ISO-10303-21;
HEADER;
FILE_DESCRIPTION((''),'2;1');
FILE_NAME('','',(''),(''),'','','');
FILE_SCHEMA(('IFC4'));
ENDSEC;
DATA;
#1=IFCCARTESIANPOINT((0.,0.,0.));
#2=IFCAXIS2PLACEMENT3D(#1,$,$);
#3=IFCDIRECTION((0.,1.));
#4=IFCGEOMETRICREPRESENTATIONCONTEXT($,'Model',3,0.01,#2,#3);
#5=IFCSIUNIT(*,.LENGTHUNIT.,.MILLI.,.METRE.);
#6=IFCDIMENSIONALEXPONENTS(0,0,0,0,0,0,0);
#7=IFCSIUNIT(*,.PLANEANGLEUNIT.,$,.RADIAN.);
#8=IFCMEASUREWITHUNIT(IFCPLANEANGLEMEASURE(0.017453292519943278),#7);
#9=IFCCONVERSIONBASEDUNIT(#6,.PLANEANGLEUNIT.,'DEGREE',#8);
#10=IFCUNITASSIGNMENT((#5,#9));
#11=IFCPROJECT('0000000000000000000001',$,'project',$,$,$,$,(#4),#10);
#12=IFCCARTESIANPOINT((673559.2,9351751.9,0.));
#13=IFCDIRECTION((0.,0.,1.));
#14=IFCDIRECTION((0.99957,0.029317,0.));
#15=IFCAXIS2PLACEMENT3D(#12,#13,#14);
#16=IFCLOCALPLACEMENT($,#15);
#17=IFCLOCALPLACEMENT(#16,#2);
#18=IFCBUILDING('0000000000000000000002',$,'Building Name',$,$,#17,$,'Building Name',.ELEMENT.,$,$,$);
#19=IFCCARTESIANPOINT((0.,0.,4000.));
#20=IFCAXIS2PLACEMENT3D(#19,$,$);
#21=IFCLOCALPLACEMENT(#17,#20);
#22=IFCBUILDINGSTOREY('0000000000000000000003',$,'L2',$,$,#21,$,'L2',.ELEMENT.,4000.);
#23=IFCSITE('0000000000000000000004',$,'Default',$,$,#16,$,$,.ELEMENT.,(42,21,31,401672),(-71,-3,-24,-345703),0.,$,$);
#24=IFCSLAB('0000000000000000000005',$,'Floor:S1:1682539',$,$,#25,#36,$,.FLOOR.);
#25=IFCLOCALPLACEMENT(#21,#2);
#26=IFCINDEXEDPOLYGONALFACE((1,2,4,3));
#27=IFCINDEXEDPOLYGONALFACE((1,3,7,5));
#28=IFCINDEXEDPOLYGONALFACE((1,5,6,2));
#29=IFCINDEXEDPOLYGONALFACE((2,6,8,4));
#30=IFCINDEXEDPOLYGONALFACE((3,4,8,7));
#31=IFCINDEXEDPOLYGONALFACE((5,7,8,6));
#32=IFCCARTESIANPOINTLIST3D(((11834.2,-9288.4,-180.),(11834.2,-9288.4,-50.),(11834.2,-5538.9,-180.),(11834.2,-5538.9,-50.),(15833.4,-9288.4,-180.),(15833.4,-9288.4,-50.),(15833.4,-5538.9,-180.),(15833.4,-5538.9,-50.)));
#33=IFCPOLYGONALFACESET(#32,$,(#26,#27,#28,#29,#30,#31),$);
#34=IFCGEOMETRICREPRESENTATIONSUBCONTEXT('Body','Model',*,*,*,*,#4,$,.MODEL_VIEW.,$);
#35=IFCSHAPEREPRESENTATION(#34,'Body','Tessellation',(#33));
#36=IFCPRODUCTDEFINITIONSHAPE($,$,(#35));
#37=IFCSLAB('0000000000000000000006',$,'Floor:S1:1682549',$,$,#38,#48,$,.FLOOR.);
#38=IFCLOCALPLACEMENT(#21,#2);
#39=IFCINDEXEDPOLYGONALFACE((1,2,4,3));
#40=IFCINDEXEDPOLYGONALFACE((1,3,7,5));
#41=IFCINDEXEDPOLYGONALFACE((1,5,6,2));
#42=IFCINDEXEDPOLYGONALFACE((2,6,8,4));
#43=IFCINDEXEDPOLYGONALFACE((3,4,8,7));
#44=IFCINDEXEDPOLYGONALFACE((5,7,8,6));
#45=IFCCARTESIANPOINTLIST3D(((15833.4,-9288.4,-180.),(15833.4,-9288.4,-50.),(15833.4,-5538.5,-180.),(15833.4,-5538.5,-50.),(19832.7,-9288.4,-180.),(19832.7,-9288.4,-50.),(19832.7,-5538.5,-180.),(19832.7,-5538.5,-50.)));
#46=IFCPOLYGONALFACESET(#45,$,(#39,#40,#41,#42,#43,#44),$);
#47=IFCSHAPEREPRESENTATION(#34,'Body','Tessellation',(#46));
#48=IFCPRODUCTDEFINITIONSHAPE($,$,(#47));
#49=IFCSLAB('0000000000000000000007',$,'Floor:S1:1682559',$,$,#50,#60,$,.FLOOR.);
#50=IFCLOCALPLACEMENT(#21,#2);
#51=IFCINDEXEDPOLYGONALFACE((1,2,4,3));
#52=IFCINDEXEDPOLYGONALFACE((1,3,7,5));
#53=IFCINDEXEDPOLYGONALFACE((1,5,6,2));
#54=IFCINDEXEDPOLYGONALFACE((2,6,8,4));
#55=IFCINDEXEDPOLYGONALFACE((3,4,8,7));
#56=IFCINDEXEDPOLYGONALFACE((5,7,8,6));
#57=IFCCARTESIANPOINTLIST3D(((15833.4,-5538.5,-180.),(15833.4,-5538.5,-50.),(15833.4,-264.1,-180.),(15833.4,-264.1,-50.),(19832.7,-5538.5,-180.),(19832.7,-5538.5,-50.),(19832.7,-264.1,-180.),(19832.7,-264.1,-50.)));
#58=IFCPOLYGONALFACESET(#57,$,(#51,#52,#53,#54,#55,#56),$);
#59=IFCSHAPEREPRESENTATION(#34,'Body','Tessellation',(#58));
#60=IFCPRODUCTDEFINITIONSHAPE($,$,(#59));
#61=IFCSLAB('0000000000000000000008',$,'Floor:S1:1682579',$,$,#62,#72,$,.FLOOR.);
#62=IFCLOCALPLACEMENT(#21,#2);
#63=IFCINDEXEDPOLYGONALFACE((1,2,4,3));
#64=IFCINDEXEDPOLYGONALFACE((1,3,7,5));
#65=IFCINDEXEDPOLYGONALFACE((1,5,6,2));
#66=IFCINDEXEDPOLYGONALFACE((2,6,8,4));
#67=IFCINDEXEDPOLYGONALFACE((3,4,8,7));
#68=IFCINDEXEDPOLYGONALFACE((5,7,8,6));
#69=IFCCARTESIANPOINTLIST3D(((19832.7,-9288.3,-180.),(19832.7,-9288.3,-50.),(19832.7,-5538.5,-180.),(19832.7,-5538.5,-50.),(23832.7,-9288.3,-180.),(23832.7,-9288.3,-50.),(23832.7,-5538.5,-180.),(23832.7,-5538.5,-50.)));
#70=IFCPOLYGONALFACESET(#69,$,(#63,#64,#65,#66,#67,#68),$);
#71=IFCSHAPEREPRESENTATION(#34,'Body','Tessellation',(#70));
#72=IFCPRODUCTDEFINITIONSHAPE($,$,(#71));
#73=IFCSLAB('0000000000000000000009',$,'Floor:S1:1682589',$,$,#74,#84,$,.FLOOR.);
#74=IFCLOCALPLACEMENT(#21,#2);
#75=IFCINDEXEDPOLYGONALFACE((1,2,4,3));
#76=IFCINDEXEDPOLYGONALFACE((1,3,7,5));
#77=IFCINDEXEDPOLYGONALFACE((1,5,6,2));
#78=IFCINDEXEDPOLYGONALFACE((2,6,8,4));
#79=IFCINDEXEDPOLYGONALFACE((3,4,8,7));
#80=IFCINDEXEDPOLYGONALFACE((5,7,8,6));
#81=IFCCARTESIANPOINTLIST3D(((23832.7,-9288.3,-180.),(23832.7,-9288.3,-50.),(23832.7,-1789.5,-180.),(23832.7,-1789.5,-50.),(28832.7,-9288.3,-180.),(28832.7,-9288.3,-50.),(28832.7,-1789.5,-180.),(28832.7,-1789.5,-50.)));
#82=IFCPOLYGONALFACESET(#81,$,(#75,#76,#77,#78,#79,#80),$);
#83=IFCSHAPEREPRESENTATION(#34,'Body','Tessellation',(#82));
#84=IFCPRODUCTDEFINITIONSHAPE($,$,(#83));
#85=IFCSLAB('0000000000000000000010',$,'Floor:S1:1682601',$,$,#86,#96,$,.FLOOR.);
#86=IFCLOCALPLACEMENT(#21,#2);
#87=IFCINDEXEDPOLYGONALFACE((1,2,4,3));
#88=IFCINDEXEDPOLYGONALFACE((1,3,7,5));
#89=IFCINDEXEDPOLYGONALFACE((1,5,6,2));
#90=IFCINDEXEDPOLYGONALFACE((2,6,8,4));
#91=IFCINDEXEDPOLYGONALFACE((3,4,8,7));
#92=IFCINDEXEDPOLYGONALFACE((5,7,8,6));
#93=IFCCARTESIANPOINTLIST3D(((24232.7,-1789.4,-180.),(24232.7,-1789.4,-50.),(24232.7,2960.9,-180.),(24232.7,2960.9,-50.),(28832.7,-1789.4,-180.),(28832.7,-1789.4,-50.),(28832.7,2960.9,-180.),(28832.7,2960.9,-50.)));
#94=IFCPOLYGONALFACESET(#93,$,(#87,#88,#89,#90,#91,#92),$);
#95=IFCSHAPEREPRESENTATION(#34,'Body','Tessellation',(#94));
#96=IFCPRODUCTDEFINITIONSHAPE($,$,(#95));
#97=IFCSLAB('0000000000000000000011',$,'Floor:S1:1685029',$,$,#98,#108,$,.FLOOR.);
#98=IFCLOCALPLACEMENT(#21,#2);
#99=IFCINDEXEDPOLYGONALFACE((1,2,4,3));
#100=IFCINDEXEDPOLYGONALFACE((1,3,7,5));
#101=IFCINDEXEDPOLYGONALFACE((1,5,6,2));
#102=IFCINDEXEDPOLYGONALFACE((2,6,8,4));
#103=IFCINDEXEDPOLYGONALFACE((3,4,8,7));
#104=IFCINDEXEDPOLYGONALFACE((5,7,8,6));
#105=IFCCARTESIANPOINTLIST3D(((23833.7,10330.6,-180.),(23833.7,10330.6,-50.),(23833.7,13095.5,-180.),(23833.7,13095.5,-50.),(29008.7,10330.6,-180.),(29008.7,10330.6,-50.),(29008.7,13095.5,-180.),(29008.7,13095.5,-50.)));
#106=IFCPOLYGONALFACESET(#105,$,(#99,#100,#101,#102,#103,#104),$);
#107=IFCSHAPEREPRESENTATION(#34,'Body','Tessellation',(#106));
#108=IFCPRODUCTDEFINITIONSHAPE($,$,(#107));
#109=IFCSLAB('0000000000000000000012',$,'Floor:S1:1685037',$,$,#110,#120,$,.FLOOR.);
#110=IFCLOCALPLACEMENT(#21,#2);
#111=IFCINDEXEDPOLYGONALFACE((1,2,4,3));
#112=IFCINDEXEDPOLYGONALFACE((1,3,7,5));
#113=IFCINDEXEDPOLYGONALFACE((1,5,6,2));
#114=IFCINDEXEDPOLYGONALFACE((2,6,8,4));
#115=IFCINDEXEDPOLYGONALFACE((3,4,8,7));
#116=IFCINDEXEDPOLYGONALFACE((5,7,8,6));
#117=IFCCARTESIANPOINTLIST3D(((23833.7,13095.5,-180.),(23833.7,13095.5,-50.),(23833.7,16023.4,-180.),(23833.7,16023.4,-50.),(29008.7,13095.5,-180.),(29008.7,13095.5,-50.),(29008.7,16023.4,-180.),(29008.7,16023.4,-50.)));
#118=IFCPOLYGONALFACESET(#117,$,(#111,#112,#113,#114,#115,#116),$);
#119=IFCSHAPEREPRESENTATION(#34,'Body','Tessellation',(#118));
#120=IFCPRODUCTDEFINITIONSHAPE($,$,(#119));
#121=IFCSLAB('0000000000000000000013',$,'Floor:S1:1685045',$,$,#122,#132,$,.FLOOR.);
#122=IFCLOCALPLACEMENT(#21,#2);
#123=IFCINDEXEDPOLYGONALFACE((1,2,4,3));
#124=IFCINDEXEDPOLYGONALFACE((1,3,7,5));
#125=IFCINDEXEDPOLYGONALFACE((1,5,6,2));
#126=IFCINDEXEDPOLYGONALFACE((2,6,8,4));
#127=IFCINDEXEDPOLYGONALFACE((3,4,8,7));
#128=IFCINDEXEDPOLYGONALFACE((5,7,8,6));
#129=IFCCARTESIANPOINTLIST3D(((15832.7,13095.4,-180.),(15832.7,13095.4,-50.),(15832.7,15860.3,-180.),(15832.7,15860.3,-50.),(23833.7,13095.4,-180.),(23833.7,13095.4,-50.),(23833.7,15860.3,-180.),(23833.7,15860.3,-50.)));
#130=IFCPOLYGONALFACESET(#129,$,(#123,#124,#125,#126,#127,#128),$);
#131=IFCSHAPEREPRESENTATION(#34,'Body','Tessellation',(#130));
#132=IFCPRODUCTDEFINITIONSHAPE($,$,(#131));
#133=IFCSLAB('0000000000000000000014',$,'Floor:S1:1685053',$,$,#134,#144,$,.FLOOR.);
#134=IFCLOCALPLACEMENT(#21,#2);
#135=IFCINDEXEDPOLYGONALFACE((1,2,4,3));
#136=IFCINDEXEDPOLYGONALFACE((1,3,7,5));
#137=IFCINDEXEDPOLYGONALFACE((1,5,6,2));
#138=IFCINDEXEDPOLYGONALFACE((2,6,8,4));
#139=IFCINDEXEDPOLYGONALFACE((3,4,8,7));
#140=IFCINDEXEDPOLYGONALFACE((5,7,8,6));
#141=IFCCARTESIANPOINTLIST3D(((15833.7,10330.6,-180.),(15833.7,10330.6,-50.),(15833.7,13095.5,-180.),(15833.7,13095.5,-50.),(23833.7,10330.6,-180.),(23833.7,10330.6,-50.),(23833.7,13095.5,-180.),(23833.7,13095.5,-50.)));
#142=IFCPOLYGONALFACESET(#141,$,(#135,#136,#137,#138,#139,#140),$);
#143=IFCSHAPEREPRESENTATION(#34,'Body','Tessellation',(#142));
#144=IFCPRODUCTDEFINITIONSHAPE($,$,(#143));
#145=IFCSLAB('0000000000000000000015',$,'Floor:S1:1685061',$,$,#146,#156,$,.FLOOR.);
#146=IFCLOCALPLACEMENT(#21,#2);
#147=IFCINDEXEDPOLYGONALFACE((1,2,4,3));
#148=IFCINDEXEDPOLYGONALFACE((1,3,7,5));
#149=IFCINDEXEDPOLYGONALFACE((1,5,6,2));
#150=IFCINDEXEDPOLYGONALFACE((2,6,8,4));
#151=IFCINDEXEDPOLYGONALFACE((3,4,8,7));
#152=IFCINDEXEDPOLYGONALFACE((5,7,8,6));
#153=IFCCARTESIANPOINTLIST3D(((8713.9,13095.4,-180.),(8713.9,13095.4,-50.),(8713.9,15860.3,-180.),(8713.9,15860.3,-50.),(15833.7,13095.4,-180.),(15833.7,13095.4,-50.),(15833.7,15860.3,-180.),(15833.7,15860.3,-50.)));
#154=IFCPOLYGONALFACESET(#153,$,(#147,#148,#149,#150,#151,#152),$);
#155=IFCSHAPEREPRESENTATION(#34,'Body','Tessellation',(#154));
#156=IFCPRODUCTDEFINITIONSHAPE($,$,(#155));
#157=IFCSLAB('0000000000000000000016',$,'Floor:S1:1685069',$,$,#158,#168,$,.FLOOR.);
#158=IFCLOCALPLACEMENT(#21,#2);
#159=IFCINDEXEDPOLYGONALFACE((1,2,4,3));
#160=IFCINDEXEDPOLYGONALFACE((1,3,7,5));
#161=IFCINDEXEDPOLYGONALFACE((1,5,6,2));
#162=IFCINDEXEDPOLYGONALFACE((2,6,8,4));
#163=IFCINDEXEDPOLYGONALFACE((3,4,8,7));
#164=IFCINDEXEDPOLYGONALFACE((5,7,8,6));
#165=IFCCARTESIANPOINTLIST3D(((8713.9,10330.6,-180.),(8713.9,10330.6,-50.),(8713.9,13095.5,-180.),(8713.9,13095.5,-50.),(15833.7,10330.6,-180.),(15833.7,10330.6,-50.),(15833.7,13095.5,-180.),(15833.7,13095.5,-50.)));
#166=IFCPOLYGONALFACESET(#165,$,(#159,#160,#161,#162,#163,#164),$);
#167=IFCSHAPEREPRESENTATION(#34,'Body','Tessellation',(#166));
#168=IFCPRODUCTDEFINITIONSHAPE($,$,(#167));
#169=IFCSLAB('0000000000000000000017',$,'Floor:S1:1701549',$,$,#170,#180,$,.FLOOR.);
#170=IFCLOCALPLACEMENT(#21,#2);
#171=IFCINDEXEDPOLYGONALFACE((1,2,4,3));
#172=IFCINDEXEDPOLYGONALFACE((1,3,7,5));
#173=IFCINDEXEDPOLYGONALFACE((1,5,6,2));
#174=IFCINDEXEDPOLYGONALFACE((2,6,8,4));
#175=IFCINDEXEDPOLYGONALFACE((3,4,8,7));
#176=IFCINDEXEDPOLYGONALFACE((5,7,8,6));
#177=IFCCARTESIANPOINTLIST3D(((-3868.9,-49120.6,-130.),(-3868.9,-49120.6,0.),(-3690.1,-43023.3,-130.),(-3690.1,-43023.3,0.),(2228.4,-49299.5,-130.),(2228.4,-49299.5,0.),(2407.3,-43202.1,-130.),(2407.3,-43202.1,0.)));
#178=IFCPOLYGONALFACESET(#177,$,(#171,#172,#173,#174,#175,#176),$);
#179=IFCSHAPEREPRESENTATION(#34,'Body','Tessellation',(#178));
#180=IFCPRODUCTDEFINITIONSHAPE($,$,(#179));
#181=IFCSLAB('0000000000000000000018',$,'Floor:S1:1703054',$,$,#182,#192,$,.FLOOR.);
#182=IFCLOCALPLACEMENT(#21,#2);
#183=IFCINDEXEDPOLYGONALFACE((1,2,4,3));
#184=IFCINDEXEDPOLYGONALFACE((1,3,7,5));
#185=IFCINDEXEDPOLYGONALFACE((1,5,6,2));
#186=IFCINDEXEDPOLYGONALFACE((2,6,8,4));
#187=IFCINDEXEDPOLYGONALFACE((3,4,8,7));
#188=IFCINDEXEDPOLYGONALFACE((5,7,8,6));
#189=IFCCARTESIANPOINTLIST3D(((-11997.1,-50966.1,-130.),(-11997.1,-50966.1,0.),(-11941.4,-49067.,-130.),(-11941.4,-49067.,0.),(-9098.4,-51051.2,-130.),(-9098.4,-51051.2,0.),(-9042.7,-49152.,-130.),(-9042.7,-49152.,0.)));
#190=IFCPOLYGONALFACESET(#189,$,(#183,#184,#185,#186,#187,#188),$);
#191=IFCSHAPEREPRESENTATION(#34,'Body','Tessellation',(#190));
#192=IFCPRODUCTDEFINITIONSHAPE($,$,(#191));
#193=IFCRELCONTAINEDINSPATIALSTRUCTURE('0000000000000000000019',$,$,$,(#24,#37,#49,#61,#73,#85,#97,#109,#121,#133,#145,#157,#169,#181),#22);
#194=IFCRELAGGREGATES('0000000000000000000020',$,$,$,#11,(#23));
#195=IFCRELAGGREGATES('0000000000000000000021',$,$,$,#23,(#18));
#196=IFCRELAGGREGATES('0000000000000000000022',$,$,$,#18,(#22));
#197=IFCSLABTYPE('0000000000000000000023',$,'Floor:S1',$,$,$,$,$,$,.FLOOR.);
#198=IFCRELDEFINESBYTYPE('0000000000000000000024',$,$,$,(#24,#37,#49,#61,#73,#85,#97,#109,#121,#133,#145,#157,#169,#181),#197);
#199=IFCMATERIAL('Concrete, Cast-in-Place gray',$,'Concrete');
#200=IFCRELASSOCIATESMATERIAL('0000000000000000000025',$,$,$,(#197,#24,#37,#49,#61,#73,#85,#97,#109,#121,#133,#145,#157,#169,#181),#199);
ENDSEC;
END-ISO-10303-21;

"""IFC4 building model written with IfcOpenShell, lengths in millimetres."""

from ifc_helpers import new_model, entity, si_unit, converted_unit, direction, frame, origin, place, context, subcontext, project, spatial, indexed_curve, outline, extrude, material, type_object, element, save


model = new_model("IFC4")

# Units and contexts
model_context = context("Model", 3, precision=0.01, world=origin(), true_north=direction((0.0, 1.0)))
body_context = subcontext(model_context, "Body", "Model", "MODEL_VIEW")
ifc_project = project(units=[si_unit("LENGTHUNIT", "METRE", prefix="MILLI"), converted_unit("PLANEANGLEUNIT", "DEGREE", entity("IfcPlaneAngleMeasure", 0.017453292519943278), si_unit("PLANEANGLEUNIT", "RADIAN"), dimensions=[0, 0, 0, 0, 0, 0, 0])], contexts=[model_context])

# Site, building, storey
site_placement = place(None, frame((673559.2, 9351751.9, 0.0), z_axis=(0.0, 0.0, 1.0), x_axis=(0.99957, 0.029317, 0.0)))
site = spatial("IfcSite", under=ifc_project, at=site_placement, Name="Default", CompositionType="ELEMENT", RefLatitude=(42, 21, 31, 401672), RefLongitude=(-71, -3, -24, -345703), RefElevation=0.0)
building_placement = place(site_placement, origin())
building = spatial("IfcBuilding", under=site, at=building_placement, Name="Building Name", LongName="Building Name", CompositionType="ELEMENT")
storey_placement = place(building_placement, frame((0.0, 0.0, 4000.0)))
storey = spatial("IfcBuildingStorey", under=building, at=storey_placement, Name="L2", LongName="L2", CompositionType="ELEMENT", Elevation=4000.0)

# Slabs
ifc_material = material(Name="Concrete, Cast-in-Place gray", Category="Concrete")
slab_type_1 = type_object("IfcSlabType", Name="Floor:S1", PredefinedType="FLOOR", material=ifc_material)
slab_1_placement = place(storey_placement, origin())
element("IfcSlab", 1, at=slab_1_placement, inside=storey, type_object=slab_type_1, material=ifc_material, Name="Floor:S1:1682539", PredefinedType="FLOOR", context=body_context, shape_type="SweptSolid", body=[
    extrude(outline(indexed_curve([(-1874.7, -1999.6), (1874.7, -1999.6), (1874.7, 1999.6), (-1874.7, 1999.6), (-1874.7, -1999.6)], self_intersect=False)), frame((13833.8, -7413.6, -50.0), z_axis=(0.0, 0.0, -1.0), x_axis=(0.0, 1.0, 0.0)), (0.0, 0.0, 1.0), 130.0),
])
slab_2_placement = place(storey_placement, origin())
element("IfcSlab", 2, at=slab_2_placement, inside=storey, type_object=slab_type_1, material=ifc_material, Name="Floor:S1:1682549", PredefinedType="FLOOR", context=body_context, shape_type="SweptSolid", body=[
    extrude(outline(indexed_curve([(-1874.9, -1999.6), (1874.9, -1999.6), (1874.9, 1999.6), (-1874.9, 1999.6), (-1874.9, -1999.6)], self_intersect=False)), frame((17833.0, -7413.5, -50.0), z_axis=(0.0, 0.0, -1.0), x_axis=(0.0, 1.0, 0.0)), (0.0, 0.0, 1.0), 130.0),
])
slab_3_placement = place(storey_placement, origin())
element("IfcSlab", 3, at=slab_3_placement, inside=storey, type_object=slab_type_1, material=ifc_material, Name="Floor:S1:1682559", PredefinedType="FLOOR", context=body_context, shape_type="SweptSolid", body=[
    extrude(outline(indexed_curve([(-2637.2, -1999.6), (2637.2, -1999.6), (2637.2, 1999.6), (-2637.2, 1999.6), (-2637.2, -1999.6)], self_intersect=False)), frame((17833.0, -2901.3, -50.0), z_axis=(0.0, 0.0, -1.0), x_axis=(0.0, 1.0, 0.0)), (0.0, 0.0, 1.0), 130.0),
])
slab_4_placement = place(storey_placement, origin())
element("IfcSlab", 4, at=slab_4_placement, inside=storey, type_object=slab_type_1, material=ifc_material, Name="Floor:S1:1682579", PredefinedType="FLOOR", context=body_context, shape_type="SweptSolid", body=[
    extrude(outline(indexed_curve([(-1874.9, -2000.0), (1874.9, -2000.0), (1874.9, 2000.0), (-1874.9, 2000.0), (-1874.9, -2000.0)], self_intersect=False)), frame((21832.7, -7413.4, -50.0), z_axis=(0.0, 0.0, -1.0), x_axis=(0.0, 1.0, 0.0)), (0.0, 0.0, 1.0), 130.0),
])
slab_5_placement = place(storey_placement, origin())
element("IfcSlab", 5, at=slab_5_placement, inside=storey, type_object=slab_type_1, material=ifc_material, Name="Floor:S1:1682589", PredefinedType="FLOOR", context=body_context, shape_type="SweptSolid", body=[
    extrude(outline(indexed_curve([(-3749.4, -2500.0), (3749.4, -2500.0), (3749.4, 2500.0), (-3749.4, 2500.0), (-3749.4, -2500.0)], self_intersect=False)), frame((26332.7, -5538.9, -50.0), z_axis=(0.0, 0.0, -1.0), x_axis=(0.0, 1.0, 0.0)), (0.0, 0.0, 1.0), 130.0),
])
slab_6_placement = place(storey_placement, origin())
element("IfcSlab", 6, at=slab_6_placement, inside=storey, type_object=slab_type_1, material=ifc_material, Name="Floor:S1:1682601", PredefinedType="FLOOR", context=body_context, shape_type="SweptSolid", body=[
    extrude(outline(indexed_curve([(-2375.2, -2300.0), (2375.2, -2300.0), (2375.2, 2300.0), (-2375.2, 2300.0), (-2375.2, -2300.0)], self_intersect=False)), frame((26532.7, 585.8, -50.0), z_axis=(0.0, 0.0, -1.0), x_axis=(0.0, 1.0, 0.0)), (0.0, 0.0, 1.0), 130.0),
])
slab_7_placement = place(storey_placement, origin())
element("IfcSlab", 7, at=slab_7_placement, inside=storey, type_object=slab_type_1, material=ifc_material, Name="Floor:S1:1685029", PredefinedType="FLOOR", context=body_context, shape_type="SweptSolid", body=[
    extrude(outline(indexed_curve([(-1382.4, -2587.5), (1382.4, -2587.5), (1382.4, 2587.5), (-1382.4, 2587.5), (-1382.4, -2587.5)], self_intersect=False)), frame((26421.2, 11713.0, -50.0), z_axis=(0.0, 0.0, -1.0), x_axis=(0.0, 1.0, 0.0)), (0.0, 0.0, 1.0), 130.0),
])
slab_8_placement = place(storey_placement, origin())
element("IfcSlab", 8, at=slab_8_placement, inside=storey, type_object=slab_type_1, material=ifc_material, Name="Floor:S1:1685037", PredefinedType="FLOOR", context=body_context, shape_type="SweptSolid", body=[
    extrude(outline(indexed_curve([(-1464.0, -2587.5), (1464.0, -2587.5), (1464.0, 2587.5), (-1464.0, 2587.5), (-1464.0, -2587.5)], self_intersect=False)), frame((26421.2, 14559.4, -50.0), z_axis=(0.0, 0.0, -1.0), x_axis=(0.0, 1.0, 0.0)), (0.0, 0.0, 1.0), 130.0),
])
slab_9_placement = place(storey_placement, origin())
element("IfcSlab", 9, at=slab_9_placement, inside=storey, type_object=slab_type_1, material=ifc_material, Name="Floor:S1:1685045", PredefinedType="FLOOR", context=body_context, shape_type="SweptSolid", body=[
    extrude(outline(indexed_curve([(-1382.4, -4000.5), (1382.4, -4000.5), (1382.4, 4000.5), (-1382.4, 4000.5), (-1382.4, -4000.5)], self_intersect=False)), frame((19833.2, 14477.9, -50.0), z_axis=(0.0, 0.0, -1.0), x_axis=(0.0, 1.0, 0.0)), (0.0, 0.0, 1.0), 130.0),
])
slab_10_placement = place(storey_placement, origin())
element("IfcSlab", 10, at=slab_10_placement, inside=storey, type_object=slab_type_1, material=ifc_material, Name="Floor:S1:1685053", PredefinedType="FLOOR", context=body_context, shape_type="SweptSolid", body=[
    extrude(outline(indexed_curve([(-1382.4, -4000.0), (1382.4, -4000.0), (1382.4, 4000.0), (-1382.4, 4000.0), (-1382.4, -4000.0)], self_intersect=False)), frame((19833.7, 11713.0, -50.0), z_axis=(0.0, 0.0, -1.0), x_axis=(0.0, 1.0, 0.0)), (0.0, 0.0, 1.0), 130.0),
])
slab_11_placement = place(storey_placement, origin())
element("IfcSlab", 11, at=slab_11_placement, inside=storey, type_object=slab_type_1, material=ifc_material, Name="Floor:S1:1685061", PredefinedType="FLOOR", context=body_context, shape_type="SweptSolid", body=[
    extrude(outline(indexed_curve([(-1382.4, -3559.9), (1382.4, -3559.9), (1382.4, 3559.9), (-1382.4, 3559.9), (-1382.4, -3559.9)], self_intersect=False)), frame((12273.8, 14477.9, -50.0), z_axis=(0.0, 0.0, -1.0), x_axis=(0.0, 1.0, 0.0)), (0.0, 0.0, 1.0), 130.0),
])
slab_12_placement = place(storey_placement, origin())
element("IfcSlab", 12, at=slab_12_placement, inside=storey, type_object=slab_type_1, material=ifc_material, Name="Floor:S1:1685069", PredefinedType="FLOOR", context=body_context, shape_type="SweptSolid", body=[
    extrude(outline(indexed_curve([(-1382.4, -3559.9), (1382.4, -3559.9), (1382.4, 3559.9), (-1382.4, 3559.9), (-1382.4, -3559.9)], self_intersect=False)), frame((12273.8, 11713.0, -50.0), z_axis=(0.0, 0.0, -1.0), x_axis=(0.0, 1.0, 0.0)), (0.0, 0.0, 1.0), 130.0),
])
slab_13_placement = place(storey_placement, origin())
element("IfcSlab", 13, at=slab_13_placement, inside=storey, type_object=slab_type_1, material=ifc_material, Name="Floor:S1:1701549", PredefinedType="FLOOR", context=body_context, shape_type="SweptSolid", body=[
    extrude(outline(indexed_curve([(-3050.0, -3050.0), (3050.0, -3050.0), (3050.0, 3050.0), (-3050.0, 3050.0), (-3050.0, -3050.0)], self_intersect=False)), frame((-730.8, -46161.4, 0.0), z_axis=(0.0, 0.0, -1.0), x_axis=(0.99957, -0.029317, 0.0)), (0.0, 0.0, 1.0), 130.0),
])
slab_14_placement = place(storey_placement, origin())
element("IfcSlab", 14, at=slab_14_placement, inside=storey, type_object=slab_type_1, material=ifc_material, Name="Floor:S1:1703054", PredefinedType="FLOOR", context=body_context, shape_type="SweptSolid", body=[
    extrude(outline(indexed_curve([(-950.0, -1450.0), (950.0, -1450.0), (950.0, 1450.0), (-950.0, 1450.0), (-950.0, -1450.0)], self_intersect=False)), frame((-10519.9, -50059.1, 0.0), z_axis=(0.0, 0.0, -1.0), x_axis=(-0.029317, -0.99957, 0.0)), (0.0, 0.0, 1.0), 130.0),
])

save(model, "model.ifc")
